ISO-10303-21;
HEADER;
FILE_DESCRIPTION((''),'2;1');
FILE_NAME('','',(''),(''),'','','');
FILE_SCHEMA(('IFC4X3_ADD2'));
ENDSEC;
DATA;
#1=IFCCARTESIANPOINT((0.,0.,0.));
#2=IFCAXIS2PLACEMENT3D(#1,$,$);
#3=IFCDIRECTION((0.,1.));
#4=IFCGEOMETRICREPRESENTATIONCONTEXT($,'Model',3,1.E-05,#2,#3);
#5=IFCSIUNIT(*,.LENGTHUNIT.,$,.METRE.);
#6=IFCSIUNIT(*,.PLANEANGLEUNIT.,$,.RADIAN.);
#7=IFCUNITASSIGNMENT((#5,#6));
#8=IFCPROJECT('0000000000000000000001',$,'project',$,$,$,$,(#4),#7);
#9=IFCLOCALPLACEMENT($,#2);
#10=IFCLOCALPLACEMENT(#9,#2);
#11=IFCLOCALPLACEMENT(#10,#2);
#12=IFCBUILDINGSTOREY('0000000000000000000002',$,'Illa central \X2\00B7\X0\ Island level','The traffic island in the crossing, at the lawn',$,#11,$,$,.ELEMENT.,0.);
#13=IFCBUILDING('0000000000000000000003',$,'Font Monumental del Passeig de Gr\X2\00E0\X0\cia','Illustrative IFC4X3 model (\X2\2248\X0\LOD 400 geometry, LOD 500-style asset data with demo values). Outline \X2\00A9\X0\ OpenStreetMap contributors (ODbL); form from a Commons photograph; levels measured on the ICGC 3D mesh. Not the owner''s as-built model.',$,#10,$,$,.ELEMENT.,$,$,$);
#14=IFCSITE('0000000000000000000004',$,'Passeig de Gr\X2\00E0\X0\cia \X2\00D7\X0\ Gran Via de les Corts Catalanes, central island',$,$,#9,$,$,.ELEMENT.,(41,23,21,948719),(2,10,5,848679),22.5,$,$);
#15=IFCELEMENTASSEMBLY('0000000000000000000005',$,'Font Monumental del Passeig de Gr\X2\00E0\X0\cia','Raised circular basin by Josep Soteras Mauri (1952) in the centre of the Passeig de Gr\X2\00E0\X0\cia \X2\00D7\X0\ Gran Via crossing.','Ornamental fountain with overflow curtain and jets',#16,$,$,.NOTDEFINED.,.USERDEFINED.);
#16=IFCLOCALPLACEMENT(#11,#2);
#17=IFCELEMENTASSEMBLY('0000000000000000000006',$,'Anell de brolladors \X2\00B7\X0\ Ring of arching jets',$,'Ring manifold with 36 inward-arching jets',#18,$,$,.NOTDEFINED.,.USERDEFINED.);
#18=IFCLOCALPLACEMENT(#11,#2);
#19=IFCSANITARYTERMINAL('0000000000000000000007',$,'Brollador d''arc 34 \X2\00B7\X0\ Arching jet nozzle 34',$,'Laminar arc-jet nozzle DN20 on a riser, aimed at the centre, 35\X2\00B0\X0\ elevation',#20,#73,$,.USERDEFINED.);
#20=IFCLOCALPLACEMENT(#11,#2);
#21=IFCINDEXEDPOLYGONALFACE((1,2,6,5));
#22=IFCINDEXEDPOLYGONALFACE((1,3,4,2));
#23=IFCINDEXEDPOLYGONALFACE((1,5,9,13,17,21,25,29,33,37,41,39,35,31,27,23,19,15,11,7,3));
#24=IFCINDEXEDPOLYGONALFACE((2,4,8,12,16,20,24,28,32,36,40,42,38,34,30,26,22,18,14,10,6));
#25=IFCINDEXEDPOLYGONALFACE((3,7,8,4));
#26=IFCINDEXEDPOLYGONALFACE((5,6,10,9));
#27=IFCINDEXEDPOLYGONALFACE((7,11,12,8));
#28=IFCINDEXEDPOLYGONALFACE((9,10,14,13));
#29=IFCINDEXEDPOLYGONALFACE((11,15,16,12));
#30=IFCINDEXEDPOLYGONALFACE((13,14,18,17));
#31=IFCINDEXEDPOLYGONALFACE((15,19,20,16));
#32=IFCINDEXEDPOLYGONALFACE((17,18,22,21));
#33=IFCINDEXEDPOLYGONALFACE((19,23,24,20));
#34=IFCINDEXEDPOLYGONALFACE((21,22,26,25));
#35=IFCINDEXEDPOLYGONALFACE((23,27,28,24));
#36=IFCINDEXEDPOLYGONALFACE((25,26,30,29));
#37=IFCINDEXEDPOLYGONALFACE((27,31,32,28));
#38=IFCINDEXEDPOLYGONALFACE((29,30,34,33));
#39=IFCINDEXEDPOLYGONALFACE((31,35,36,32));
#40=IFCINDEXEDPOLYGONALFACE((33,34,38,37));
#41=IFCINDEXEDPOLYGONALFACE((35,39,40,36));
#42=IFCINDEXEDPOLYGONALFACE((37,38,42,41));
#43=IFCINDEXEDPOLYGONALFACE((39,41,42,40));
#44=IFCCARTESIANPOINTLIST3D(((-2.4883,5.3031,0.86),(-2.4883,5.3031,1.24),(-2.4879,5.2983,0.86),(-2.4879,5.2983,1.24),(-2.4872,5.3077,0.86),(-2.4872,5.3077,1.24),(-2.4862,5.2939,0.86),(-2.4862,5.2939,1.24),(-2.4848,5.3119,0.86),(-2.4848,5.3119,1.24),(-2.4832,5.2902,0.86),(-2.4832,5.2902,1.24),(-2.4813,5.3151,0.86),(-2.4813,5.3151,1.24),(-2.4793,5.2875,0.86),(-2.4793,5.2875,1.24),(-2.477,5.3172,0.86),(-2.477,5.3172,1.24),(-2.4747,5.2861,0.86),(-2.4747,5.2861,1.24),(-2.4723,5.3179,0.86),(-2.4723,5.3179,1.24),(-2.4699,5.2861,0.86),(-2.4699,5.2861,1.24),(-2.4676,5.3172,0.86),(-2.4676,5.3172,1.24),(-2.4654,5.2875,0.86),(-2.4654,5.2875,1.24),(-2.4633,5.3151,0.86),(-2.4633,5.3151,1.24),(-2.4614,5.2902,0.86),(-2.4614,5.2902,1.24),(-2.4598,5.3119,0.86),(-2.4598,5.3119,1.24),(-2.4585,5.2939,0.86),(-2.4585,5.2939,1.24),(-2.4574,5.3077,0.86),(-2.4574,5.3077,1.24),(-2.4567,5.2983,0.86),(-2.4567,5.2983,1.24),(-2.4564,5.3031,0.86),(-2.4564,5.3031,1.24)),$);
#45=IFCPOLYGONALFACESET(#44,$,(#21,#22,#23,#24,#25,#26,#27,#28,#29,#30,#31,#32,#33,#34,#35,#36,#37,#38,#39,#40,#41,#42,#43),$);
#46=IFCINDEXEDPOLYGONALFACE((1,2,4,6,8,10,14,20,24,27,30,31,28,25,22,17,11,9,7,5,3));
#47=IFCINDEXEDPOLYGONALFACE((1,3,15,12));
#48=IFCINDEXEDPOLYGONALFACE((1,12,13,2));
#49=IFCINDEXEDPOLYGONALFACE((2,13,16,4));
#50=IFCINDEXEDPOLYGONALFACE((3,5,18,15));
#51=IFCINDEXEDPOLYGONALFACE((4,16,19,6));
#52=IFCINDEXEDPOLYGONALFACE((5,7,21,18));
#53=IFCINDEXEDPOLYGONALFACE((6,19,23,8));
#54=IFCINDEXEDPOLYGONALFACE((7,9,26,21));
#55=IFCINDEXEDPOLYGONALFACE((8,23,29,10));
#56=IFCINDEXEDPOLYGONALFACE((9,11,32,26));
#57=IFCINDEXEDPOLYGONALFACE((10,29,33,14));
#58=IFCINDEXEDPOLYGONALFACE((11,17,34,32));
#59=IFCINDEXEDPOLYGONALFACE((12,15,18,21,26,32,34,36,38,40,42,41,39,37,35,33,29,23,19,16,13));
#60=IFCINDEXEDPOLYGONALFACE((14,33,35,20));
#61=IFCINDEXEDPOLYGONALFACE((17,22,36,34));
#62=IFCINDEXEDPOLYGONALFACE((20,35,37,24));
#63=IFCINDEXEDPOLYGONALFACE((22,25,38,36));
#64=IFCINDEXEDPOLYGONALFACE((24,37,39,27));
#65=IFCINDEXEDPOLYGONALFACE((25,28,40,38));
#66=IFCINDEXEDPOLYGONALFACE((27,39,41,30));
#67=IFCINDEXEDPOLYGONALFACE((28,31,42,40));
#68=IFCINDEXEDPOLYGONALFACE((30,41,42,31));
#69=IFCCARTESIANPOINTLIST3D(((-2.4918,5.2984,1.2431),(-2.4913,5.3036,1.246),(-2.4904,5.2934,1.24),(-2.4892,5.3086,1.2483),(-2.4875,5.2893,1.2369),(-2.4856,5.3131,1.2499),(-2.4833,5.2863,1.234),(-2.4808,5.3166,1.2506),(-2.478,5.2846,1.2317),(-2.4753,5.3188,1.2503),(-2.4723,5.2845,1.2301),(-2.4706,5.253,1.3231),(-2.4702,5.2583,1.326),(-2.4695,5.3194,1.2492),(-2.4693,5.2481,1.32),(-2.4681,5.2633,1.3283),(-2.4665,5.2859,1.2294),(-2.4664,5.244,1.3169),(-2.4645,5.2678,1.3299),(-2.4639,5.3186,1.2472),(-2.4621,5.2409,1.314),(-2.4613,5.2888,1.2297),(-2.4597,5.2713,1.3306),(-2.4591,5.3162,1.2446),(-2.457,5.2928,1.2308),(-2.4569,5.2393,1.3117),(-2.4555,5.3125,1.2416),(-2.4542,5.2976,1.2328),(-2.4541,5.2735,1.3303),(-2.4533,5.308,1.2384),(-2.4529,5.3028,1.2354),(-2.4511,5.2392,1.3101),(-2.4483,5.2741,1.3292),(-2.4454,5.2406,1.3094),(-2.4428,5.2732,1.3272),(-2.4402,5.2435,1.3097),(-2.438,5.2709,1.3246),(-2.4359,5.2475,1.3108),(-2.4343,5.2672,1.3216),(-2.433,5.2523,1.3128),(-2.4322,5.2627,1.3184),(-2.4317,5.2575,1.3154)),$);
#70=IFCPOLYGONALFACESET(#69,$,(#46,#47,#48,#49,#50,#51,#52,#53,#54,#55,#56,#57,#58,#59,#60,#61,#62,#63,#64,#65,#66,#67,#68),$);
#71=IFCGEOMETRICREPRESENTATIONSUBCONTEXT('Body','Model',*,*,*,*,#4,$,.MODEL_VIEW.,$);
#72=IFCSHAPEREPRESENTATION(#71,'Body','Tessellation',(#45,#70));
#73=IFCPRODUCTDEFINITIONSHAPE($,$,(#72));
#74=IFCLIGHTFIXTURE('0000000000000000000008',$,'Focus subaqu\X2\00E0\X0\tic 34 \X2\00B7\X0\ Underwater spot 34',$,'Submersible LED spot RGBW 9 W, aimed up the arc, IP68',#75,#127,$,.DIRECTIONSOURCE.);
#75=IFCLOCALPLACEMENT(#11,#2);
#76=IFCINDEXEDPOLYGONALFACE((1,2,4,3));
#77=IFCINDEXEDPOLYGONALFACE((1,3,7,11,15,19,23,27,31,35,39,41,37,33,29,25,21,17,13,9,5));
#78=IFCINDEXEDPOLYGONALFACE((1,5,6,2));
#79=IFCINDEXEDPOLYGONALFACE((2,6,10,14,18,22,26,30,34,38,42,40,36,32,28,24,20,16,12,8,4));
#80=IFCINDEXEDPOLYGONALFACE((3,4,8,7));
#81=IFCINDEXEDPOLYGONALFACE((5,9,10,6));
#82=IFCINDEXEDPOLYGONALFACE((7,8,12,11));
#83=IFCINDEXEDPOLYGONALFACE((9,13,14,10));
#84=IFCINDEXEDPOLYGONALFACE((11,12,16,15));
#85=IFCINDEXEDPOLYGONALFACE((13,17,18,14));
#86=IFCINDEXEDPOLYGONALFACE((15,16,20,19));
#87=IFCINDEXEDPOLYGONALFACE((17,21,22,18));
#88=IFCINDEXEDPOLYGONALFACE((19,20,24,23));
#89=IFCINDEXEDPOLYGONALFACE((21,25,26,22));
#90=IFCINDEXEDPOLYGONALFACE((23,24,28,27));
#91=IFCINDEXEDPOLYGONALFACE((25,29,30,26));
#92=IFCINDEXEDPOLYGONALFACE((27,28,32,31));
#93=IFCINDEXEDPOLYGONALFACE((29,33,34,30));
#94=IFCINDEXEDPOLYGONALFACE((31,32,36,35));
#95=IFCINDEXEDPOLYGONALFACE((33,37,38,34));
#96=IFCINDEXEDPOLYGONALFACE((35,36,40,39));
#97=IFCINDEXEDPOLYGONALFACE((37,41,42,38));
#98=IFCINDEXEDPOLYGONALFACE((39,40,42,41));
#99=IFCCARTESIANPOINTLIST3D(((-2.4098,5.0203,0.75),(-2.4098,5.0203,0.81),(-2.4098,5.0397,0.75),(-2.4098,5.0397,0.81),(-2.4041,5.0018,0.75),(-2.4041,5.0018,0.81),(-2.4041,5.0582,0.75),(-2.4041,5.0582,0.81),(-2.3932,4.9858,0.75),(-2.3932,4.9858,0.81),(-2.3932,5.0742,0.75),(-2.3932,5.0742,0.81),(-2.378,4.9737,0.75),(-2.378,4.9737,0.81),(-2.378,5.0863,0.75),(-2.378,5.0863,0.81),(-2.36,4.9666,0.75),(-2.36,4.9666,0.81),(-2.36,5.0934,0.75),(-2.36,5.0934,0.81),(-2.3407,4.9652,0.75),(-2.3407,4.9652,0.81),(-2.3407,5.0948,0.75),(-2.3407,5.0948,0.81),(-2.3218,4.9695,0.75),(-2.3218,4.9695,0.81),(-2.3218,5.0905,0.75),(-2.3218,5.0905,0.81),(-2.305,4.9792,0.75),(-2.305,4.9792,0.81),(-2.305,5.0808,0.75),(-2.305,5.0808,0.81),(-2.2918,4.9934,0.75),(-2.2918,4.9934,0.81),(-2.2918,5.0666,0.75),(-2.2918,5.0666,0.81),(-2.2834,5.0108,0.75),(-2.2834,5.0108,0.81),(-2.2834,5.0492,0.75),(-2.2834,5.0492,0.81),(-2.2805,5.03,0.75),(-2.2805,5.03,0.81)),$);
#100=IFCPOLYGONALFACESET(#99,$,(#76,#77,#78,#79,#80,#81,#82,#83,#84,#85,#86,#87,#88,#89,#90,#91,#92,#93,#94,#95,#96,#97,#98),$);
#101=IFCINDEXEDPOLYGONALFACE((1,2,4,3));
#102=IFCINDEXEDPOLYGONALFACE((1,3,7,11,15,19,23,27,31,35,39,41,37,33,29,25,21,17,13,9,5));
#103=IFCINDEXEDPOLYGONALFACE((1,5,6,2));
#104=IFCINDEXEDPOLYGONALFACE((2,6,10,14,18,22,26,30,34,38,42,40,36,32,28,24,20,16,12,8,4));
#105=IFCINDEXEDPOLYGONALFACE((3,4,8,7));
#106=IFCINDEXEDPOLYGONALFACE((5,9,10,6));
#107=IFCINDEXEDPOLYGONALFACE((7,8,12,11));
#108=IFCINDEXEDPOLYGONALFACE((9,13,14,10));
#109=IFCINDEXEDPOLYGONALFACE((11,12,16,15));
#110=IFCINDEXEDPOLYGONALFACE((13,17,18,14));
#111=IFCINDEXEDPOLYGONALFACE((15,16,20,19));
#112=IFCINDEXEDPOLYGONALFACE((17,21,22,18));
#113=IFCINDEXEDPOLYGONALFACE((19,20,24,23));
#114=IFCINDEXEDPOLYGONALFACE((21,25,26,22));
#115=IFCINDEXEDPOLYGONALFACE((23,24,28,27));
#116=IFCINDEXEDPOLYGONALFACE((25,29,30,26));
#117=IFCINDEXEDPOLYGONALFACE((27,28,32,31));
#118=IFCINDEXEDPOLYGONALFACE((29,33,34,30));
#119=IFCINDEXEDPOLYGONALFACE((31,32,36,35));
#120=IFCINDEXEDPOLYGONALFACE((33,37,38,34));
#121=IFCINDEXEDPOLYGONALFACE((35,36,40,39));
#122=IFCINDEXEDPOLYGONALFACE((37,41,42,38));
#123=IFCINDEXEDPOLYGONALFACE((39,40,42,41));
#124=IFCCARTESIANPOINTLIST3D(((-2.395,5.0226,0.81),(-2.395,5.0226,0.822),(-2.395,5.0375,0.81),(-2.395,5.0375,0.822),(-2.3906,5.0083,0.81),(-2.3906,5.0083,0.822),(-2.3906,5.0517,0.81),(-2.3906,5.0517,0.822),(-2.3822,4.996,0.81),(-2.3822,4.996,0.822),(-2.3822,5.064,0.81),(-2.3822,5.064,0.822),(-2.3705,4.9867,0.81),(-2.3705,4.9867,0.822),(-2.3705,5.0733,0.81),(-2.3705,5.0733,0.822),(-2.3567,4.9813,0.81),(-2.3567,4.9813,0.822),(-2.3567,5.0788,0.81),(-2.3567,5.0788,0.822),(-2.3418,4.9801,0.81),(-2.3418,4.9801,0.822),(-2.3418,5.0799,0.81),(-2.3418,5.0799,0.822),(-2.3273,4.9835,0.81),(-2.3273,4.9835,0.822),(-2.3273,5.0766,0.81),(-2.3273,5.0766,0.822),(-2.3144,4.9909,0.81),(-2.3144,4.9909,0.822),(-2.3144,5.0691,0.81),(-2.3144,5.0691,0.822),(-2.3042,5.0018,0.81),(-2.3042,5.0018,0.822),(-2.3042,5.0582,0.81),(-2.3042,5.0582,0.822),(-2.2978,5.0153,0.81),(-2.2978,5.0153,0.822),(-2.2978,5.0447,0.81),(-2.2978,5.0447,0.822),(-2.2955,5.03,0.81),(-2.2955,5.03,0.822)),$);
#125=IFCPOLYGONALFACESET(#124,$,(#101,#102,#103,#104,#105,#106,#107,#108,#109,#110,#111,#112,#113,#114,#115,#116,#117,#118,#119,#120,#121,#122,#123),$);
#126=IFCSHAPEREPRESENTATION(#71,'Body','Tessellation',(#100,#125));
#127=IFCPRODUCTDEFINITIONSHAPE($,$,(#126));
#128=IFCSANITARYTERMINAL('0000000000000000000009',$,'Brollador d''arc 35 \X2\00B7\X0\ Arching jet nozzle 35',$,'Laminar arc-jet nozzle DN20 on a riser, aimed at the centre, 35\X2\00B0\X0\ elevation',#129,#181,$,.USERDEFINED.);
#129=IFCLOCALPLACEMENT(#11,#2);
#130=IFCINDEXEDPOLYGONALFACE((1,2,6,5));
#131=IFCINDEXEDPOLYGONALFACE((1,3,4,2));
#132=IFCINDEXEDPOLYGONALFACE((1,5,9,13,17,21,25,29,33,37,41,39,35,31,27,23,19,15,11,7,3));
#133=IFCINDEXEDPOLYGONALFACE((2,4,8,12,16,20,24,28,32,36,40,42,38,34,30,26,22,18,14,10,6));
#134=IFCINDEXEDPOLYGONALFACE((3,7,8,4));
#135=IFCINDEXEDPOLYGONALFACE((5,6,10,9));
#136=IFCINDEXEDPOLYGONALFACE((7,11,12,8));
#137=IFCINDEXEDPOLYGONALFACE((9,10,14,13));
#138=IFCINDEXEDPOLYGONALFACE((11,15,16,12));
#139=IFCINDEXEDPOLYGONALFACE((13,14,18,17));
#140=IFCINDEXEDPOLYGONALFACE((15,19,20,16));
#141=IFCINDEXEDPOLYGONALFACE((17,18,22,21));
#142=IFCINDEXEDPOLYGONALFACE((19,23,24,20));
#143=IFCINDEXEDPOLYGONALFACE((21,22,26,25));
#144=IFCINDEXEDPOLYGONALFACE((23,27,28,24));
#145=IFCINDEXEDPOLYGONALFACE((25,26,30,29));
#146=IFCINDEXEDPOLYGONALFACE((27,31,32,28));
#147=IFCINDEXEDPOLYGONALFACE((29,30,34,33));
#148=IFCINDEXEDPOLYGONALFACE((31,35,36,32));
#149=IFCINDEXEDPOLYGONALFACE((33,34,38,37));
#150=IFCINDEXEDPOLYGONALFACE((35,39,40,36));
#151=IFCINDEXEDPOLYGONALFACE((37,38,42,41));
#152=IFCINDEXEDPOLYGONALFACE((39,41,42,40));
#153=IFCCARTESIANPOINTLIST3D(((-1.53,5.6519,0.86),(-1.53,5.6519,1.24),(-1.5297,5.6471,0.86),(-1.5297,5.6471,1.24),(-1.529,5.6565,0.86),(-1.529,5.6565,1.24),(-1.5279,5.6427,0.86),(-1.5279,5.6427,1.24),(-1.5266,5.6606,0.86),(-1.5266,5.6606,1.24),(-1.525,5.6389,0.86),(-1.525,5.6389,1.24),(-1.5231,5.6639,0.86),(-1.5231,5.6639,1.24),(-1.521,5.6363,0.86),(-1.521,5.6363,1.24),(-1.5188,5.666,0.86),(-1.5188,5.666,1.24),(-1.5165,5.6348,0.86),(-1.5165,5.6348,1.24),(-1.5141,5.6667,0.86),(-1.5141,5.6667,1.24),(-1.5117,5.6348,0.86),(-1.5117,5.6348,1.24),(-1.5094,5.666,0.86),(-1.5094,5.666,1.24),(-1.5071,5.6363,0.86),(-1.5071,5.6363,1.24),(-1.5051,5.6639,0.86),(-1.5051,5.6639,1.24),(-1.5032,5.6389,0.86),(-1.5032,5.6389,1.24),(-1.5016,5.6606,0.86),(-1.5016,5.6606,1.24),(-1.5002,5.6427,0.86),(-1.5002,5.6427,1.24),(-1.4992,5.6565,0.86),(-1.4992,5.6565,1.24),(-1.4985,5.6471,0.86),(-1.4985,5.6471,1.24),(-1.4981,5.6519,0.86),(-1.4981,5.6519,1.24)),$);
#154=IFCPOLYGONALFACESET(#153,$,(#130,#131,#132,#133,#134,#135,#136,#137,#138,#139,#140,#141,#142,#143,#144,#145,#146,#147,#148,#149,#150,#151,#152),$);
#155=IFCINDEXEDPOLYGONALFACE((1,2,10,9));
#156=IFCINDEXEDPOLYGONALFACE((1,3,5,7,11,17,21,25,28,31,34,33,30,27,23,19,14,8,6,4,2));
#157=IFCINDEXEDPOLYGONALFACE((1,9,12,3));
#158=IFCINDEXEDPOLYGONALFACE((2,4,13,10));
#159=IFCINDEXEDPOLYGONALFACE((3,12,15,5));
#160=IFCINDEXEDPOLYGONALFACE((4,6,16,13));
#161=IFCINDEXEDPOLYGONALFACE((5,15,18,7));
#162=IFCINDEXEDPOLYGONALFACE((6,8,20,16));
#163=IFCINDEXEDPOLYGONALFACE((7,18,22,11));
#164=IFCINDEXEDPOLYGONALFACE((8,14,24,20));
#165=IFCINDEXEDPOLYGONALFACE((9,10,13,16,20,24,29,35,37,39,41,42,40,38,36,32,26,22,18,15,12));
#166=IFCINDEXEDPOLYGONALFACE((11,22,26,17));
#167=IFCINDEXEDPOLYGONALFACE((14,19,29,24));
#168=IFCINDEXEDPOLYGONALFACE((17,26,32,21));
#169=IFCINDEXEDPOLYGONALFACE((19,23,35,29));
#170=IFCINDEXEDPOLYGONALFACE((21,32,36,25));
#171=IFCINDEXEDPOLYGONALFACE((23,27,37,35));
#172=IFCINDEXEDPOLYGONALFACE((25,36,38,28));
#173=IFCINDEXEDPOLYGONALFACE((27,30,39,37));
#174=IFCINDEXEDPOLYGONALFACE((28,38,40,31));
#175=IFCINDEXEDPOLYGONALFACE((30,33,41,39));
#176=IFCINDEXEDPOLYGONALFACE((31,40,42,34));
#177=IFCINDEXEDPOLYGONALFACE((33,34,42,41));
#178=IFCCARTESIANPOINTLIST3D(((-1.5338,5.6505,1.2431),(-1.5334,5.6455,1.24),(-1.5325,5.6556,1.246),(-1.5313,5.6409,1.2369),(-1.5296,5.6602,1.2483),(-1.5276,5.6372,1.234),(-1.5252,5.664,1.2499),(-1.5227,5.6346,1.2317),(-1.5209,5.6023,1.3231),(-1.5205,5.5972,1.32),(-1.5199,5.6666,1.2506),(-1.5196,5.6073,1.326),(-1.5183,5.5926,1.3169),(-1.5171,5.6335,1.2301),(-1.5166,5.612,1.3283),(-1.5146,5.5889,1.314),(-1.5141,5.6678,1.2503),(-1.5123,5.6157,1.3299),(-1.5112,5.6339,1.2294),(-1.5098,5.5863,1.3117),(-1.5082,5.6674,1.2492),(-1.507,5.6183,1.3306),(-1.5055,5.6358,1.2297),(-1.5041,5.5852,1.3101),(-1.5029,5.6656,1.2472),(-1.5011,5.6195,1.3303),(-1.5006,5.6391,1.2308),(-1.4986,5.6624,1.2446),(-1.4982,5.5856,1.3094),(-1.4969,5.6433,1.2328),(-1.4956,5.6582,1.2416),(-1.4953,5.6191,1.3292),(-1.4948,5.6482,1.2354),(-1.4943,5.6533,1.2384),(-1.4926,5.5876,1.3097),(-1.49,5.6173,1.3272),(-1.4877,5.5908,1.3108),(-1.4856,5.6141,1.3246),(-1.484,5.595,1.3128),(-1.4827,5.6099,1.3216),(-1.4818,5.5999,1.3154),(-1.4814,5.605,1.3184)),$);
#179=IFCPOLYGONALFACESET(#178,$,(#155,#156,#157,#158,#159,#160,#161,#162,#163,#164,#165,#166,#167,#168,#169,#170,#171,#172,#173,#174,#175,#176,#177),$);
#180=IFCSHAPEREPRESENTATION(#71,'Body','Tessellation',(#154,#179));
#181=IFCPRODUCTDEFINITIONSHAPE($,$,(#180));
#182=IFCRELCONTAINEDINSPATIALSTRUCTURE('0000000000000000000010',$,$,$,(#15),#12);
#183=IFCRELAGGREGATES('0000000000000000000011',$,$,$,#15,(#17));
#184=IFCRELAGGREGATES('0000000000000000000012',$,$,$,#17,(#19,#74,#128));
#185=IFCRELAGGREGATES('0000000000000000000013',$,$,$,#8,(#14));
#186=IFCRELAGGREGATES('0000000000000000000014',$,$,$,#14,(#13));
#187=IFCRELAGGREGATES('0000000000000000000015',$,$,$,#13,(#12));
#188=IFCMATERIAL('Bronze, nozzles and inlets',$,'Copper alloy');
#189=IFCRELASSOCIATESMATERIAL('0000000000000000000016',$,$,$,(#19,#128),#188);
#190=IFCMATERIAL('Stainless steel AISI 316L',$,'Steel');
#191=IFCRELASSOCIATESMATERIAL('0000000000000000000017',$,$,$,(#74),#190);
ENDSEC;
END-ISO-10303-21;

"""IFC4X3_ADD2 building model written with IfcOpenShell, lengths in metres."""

from ifc_helpers import new_model, si_unit, direction, frame, origin, origin_2d_with_axis, place, context, subcontext, project, spatial, circle, extrude, material, element, aggregate, save


model = new_model("IFC4X3_ADD2")

# Units and contexts
model_context = context("Model", 3, precision=1e-05, world=origin(), true_north=direction((0.0, 1.0)))
body_context = subcontext(model_context, "Body", "Model", "MODEL_VIEW")
ifc_project = project(units=[si_unit("LENGTHUNIT", "METRE"), si_unit("PLANEANGLEUNIT", "RADIAN")], contexts=[model_context])

# Site, building, storey
site_placement = place(None, origin())
site = spatial("IfcSite", under=ifc_project, at=site_placement, Name="Passeig de Gràcia × Gran Via de les Corts Catalanes, central island", CompositionType="ELEMENT", RefLatitude=(41, 23, 21, 948719), RefLongitude=(2, 10, 5, 848679), RefElevation=22.5)
building_placement = place(site_placement, origin())
building = spatial("IfcBuilding", under=site, at=building_placement, Name="Font Monumental del Passeig de Gràcia", Description="Illustrative IFC4X3 model (≈LOD 400 geometry, LOD 500-style asset data with demo values). Outline © OpenStreetMap contributors (ODbL); form from a Commons photograph; levels measured on the ICGC 3D mesh. Not the owner's as-built model.", CompositionType="ELEMENT")
storey_placement = place(building_placement, origin())
storey = spatial("IfcBuildingStorey", under=building, at=storey_placement, Name="Illa central · Island level", Description="The traffic island in the crossing, at the lawn", CompositionType="ELEMENT", Elevation=0.0)

# Element assemblies, sanitary terminals, light fixture
assembly_1_placement = place(building_placement, origin())
assembly_1 = element("IfcElementAssembly", 1, at=assembly_1_placement, inside=storey, Name="Font Monumental del Passeig de Gràcia", Description="Raised circular basin by Josep Soteras Mauri (1952) in the centre of the Passeig de Gràcia × Gran Via crossing.", ObjectType="Ornamental fountain with overflow curtain and jets", AssemblyPlace="NOTDEFINED", PredefinedType="USERDEFINED")
assembly_2_placement = place(building_placement, origin())
assembly_2 = element("IfcElementAssembly", 2, at=assembly_2_placement, Name="Anell de brolladors · Ring of arching jets", ObjectType="Ring manifold with 36 inward-arching jets", AssemblyPlace="NOTDEFINED", PredefinedType="USERDEFINED")
ifc_material_1 = material(Name="Stainless steel AISI 316L", Category="Steel")
ifc_material_2 = material(Name="Bronze, nozzles and inlets", Category="Copper alloy")
sanitary_terminal_1_placement = place(building_placement, origin())
sanitary_terminal_1 = element("IfcSanitaryTerminal", 3, at=sanitary_terminal_1_placement, material=ifc_material_2, Name="Brollador d'arc 34 · Arching jet nozzle 34", ObjectType="Laminar arc-jet nozzle DN20 on a riser, aimed at the centre, 35° elevation", PredefinedType="USERDEFINED", context=body_context, shape_type="SweptSolid", body=[
    extrude(circle(Radius=0.016, at=origin_2d_with_axis()), frame((-2.4723, 5.3019, 0.86), z_axis=(0.0, 0.0, 1.0), x_axis=(0.0, 1.0, 0.0)), (0.0, 0.0, 1.0), 0.38),
    extrude(circle(Radius=0.02, at=origin_2d_with_axis()), frame((-2.4723, 5.3019, 1.24), z_axis=(0.223987, -0.480342, 0.847998), x_axis=(-0.906308, -0.422618, 0.0)), (0.0, 0.0, 1.0), 0.0943),
])
light_fixture_1_placement = place(building_placement, origin())
light_fixture_1 = element("IfcLightFixture", 4, at=light_fixture_1_placement, material=ifc_material_1, Name="Focus subaquàtic 34 · Underwater spot 34", ObjectType="Submersible LED spot RGBW 9 W, aimed up the arc, IP68", PredefinedType="DIRECTIONSOURCE", context=body_context, shape_type="SweptSolid", body=[
    extrude(circle(Radius=0.065, at=origin_2d_with_axis()), frame((-2.3455, 5.03, 0.75)), (0.0, 0.0, 1.0), 0.06),
    extrude(circle(Radius=0.05, at=origin_2d_with_axis()), frame((-2.3455, 5.03, 0.81)), (0.0, 0.0, 1.0), 0.012),
])
sanitary_terminal_2_placement = place(building_placement, origin())
sanitary_terminal_2 = element("IfcSanitaryTerminal", 5, at=sanitary_terminal_2_placement, material=ifc_material_2, Name="Brollador d'arc 35 · Arching jet nozzle 35", ObjectType="Laminar arc-jet nozzle DN20 on a riser, aimed at the centre, 35° elevation", PredefinedType="USERDEFINED", context=body_context, shape_type="SweptSolid", body=[
    extrude(circle(Radius=0.016, at=origin_2d_with_axis()), frame((-1.5141, 5.6507, 0.86), z_axis=(0.0, 0.0, 1.0), x_axis=(0.0, 1.0, 0.0)), (0.0, 0.0, 1.0), 0.38),
    extrude(circle(Radius=0.02, at=origin_2d_with_axis()), frame((-1.5141, 5.6507, 1.24), z_axis=(0.137174, -0.51194, 0.847998), x_axis=(-0.965926, -0.258819, 0.0)), (0.0, 0.0, 1.0), 0.0943),
])
aggregate(assembly_1, [assembly_2])

aggregate(assembly_2, [sanitary_terminal_1, light_fixture_1, sanitary_terminal_2])

save(model, "model.ifc")
